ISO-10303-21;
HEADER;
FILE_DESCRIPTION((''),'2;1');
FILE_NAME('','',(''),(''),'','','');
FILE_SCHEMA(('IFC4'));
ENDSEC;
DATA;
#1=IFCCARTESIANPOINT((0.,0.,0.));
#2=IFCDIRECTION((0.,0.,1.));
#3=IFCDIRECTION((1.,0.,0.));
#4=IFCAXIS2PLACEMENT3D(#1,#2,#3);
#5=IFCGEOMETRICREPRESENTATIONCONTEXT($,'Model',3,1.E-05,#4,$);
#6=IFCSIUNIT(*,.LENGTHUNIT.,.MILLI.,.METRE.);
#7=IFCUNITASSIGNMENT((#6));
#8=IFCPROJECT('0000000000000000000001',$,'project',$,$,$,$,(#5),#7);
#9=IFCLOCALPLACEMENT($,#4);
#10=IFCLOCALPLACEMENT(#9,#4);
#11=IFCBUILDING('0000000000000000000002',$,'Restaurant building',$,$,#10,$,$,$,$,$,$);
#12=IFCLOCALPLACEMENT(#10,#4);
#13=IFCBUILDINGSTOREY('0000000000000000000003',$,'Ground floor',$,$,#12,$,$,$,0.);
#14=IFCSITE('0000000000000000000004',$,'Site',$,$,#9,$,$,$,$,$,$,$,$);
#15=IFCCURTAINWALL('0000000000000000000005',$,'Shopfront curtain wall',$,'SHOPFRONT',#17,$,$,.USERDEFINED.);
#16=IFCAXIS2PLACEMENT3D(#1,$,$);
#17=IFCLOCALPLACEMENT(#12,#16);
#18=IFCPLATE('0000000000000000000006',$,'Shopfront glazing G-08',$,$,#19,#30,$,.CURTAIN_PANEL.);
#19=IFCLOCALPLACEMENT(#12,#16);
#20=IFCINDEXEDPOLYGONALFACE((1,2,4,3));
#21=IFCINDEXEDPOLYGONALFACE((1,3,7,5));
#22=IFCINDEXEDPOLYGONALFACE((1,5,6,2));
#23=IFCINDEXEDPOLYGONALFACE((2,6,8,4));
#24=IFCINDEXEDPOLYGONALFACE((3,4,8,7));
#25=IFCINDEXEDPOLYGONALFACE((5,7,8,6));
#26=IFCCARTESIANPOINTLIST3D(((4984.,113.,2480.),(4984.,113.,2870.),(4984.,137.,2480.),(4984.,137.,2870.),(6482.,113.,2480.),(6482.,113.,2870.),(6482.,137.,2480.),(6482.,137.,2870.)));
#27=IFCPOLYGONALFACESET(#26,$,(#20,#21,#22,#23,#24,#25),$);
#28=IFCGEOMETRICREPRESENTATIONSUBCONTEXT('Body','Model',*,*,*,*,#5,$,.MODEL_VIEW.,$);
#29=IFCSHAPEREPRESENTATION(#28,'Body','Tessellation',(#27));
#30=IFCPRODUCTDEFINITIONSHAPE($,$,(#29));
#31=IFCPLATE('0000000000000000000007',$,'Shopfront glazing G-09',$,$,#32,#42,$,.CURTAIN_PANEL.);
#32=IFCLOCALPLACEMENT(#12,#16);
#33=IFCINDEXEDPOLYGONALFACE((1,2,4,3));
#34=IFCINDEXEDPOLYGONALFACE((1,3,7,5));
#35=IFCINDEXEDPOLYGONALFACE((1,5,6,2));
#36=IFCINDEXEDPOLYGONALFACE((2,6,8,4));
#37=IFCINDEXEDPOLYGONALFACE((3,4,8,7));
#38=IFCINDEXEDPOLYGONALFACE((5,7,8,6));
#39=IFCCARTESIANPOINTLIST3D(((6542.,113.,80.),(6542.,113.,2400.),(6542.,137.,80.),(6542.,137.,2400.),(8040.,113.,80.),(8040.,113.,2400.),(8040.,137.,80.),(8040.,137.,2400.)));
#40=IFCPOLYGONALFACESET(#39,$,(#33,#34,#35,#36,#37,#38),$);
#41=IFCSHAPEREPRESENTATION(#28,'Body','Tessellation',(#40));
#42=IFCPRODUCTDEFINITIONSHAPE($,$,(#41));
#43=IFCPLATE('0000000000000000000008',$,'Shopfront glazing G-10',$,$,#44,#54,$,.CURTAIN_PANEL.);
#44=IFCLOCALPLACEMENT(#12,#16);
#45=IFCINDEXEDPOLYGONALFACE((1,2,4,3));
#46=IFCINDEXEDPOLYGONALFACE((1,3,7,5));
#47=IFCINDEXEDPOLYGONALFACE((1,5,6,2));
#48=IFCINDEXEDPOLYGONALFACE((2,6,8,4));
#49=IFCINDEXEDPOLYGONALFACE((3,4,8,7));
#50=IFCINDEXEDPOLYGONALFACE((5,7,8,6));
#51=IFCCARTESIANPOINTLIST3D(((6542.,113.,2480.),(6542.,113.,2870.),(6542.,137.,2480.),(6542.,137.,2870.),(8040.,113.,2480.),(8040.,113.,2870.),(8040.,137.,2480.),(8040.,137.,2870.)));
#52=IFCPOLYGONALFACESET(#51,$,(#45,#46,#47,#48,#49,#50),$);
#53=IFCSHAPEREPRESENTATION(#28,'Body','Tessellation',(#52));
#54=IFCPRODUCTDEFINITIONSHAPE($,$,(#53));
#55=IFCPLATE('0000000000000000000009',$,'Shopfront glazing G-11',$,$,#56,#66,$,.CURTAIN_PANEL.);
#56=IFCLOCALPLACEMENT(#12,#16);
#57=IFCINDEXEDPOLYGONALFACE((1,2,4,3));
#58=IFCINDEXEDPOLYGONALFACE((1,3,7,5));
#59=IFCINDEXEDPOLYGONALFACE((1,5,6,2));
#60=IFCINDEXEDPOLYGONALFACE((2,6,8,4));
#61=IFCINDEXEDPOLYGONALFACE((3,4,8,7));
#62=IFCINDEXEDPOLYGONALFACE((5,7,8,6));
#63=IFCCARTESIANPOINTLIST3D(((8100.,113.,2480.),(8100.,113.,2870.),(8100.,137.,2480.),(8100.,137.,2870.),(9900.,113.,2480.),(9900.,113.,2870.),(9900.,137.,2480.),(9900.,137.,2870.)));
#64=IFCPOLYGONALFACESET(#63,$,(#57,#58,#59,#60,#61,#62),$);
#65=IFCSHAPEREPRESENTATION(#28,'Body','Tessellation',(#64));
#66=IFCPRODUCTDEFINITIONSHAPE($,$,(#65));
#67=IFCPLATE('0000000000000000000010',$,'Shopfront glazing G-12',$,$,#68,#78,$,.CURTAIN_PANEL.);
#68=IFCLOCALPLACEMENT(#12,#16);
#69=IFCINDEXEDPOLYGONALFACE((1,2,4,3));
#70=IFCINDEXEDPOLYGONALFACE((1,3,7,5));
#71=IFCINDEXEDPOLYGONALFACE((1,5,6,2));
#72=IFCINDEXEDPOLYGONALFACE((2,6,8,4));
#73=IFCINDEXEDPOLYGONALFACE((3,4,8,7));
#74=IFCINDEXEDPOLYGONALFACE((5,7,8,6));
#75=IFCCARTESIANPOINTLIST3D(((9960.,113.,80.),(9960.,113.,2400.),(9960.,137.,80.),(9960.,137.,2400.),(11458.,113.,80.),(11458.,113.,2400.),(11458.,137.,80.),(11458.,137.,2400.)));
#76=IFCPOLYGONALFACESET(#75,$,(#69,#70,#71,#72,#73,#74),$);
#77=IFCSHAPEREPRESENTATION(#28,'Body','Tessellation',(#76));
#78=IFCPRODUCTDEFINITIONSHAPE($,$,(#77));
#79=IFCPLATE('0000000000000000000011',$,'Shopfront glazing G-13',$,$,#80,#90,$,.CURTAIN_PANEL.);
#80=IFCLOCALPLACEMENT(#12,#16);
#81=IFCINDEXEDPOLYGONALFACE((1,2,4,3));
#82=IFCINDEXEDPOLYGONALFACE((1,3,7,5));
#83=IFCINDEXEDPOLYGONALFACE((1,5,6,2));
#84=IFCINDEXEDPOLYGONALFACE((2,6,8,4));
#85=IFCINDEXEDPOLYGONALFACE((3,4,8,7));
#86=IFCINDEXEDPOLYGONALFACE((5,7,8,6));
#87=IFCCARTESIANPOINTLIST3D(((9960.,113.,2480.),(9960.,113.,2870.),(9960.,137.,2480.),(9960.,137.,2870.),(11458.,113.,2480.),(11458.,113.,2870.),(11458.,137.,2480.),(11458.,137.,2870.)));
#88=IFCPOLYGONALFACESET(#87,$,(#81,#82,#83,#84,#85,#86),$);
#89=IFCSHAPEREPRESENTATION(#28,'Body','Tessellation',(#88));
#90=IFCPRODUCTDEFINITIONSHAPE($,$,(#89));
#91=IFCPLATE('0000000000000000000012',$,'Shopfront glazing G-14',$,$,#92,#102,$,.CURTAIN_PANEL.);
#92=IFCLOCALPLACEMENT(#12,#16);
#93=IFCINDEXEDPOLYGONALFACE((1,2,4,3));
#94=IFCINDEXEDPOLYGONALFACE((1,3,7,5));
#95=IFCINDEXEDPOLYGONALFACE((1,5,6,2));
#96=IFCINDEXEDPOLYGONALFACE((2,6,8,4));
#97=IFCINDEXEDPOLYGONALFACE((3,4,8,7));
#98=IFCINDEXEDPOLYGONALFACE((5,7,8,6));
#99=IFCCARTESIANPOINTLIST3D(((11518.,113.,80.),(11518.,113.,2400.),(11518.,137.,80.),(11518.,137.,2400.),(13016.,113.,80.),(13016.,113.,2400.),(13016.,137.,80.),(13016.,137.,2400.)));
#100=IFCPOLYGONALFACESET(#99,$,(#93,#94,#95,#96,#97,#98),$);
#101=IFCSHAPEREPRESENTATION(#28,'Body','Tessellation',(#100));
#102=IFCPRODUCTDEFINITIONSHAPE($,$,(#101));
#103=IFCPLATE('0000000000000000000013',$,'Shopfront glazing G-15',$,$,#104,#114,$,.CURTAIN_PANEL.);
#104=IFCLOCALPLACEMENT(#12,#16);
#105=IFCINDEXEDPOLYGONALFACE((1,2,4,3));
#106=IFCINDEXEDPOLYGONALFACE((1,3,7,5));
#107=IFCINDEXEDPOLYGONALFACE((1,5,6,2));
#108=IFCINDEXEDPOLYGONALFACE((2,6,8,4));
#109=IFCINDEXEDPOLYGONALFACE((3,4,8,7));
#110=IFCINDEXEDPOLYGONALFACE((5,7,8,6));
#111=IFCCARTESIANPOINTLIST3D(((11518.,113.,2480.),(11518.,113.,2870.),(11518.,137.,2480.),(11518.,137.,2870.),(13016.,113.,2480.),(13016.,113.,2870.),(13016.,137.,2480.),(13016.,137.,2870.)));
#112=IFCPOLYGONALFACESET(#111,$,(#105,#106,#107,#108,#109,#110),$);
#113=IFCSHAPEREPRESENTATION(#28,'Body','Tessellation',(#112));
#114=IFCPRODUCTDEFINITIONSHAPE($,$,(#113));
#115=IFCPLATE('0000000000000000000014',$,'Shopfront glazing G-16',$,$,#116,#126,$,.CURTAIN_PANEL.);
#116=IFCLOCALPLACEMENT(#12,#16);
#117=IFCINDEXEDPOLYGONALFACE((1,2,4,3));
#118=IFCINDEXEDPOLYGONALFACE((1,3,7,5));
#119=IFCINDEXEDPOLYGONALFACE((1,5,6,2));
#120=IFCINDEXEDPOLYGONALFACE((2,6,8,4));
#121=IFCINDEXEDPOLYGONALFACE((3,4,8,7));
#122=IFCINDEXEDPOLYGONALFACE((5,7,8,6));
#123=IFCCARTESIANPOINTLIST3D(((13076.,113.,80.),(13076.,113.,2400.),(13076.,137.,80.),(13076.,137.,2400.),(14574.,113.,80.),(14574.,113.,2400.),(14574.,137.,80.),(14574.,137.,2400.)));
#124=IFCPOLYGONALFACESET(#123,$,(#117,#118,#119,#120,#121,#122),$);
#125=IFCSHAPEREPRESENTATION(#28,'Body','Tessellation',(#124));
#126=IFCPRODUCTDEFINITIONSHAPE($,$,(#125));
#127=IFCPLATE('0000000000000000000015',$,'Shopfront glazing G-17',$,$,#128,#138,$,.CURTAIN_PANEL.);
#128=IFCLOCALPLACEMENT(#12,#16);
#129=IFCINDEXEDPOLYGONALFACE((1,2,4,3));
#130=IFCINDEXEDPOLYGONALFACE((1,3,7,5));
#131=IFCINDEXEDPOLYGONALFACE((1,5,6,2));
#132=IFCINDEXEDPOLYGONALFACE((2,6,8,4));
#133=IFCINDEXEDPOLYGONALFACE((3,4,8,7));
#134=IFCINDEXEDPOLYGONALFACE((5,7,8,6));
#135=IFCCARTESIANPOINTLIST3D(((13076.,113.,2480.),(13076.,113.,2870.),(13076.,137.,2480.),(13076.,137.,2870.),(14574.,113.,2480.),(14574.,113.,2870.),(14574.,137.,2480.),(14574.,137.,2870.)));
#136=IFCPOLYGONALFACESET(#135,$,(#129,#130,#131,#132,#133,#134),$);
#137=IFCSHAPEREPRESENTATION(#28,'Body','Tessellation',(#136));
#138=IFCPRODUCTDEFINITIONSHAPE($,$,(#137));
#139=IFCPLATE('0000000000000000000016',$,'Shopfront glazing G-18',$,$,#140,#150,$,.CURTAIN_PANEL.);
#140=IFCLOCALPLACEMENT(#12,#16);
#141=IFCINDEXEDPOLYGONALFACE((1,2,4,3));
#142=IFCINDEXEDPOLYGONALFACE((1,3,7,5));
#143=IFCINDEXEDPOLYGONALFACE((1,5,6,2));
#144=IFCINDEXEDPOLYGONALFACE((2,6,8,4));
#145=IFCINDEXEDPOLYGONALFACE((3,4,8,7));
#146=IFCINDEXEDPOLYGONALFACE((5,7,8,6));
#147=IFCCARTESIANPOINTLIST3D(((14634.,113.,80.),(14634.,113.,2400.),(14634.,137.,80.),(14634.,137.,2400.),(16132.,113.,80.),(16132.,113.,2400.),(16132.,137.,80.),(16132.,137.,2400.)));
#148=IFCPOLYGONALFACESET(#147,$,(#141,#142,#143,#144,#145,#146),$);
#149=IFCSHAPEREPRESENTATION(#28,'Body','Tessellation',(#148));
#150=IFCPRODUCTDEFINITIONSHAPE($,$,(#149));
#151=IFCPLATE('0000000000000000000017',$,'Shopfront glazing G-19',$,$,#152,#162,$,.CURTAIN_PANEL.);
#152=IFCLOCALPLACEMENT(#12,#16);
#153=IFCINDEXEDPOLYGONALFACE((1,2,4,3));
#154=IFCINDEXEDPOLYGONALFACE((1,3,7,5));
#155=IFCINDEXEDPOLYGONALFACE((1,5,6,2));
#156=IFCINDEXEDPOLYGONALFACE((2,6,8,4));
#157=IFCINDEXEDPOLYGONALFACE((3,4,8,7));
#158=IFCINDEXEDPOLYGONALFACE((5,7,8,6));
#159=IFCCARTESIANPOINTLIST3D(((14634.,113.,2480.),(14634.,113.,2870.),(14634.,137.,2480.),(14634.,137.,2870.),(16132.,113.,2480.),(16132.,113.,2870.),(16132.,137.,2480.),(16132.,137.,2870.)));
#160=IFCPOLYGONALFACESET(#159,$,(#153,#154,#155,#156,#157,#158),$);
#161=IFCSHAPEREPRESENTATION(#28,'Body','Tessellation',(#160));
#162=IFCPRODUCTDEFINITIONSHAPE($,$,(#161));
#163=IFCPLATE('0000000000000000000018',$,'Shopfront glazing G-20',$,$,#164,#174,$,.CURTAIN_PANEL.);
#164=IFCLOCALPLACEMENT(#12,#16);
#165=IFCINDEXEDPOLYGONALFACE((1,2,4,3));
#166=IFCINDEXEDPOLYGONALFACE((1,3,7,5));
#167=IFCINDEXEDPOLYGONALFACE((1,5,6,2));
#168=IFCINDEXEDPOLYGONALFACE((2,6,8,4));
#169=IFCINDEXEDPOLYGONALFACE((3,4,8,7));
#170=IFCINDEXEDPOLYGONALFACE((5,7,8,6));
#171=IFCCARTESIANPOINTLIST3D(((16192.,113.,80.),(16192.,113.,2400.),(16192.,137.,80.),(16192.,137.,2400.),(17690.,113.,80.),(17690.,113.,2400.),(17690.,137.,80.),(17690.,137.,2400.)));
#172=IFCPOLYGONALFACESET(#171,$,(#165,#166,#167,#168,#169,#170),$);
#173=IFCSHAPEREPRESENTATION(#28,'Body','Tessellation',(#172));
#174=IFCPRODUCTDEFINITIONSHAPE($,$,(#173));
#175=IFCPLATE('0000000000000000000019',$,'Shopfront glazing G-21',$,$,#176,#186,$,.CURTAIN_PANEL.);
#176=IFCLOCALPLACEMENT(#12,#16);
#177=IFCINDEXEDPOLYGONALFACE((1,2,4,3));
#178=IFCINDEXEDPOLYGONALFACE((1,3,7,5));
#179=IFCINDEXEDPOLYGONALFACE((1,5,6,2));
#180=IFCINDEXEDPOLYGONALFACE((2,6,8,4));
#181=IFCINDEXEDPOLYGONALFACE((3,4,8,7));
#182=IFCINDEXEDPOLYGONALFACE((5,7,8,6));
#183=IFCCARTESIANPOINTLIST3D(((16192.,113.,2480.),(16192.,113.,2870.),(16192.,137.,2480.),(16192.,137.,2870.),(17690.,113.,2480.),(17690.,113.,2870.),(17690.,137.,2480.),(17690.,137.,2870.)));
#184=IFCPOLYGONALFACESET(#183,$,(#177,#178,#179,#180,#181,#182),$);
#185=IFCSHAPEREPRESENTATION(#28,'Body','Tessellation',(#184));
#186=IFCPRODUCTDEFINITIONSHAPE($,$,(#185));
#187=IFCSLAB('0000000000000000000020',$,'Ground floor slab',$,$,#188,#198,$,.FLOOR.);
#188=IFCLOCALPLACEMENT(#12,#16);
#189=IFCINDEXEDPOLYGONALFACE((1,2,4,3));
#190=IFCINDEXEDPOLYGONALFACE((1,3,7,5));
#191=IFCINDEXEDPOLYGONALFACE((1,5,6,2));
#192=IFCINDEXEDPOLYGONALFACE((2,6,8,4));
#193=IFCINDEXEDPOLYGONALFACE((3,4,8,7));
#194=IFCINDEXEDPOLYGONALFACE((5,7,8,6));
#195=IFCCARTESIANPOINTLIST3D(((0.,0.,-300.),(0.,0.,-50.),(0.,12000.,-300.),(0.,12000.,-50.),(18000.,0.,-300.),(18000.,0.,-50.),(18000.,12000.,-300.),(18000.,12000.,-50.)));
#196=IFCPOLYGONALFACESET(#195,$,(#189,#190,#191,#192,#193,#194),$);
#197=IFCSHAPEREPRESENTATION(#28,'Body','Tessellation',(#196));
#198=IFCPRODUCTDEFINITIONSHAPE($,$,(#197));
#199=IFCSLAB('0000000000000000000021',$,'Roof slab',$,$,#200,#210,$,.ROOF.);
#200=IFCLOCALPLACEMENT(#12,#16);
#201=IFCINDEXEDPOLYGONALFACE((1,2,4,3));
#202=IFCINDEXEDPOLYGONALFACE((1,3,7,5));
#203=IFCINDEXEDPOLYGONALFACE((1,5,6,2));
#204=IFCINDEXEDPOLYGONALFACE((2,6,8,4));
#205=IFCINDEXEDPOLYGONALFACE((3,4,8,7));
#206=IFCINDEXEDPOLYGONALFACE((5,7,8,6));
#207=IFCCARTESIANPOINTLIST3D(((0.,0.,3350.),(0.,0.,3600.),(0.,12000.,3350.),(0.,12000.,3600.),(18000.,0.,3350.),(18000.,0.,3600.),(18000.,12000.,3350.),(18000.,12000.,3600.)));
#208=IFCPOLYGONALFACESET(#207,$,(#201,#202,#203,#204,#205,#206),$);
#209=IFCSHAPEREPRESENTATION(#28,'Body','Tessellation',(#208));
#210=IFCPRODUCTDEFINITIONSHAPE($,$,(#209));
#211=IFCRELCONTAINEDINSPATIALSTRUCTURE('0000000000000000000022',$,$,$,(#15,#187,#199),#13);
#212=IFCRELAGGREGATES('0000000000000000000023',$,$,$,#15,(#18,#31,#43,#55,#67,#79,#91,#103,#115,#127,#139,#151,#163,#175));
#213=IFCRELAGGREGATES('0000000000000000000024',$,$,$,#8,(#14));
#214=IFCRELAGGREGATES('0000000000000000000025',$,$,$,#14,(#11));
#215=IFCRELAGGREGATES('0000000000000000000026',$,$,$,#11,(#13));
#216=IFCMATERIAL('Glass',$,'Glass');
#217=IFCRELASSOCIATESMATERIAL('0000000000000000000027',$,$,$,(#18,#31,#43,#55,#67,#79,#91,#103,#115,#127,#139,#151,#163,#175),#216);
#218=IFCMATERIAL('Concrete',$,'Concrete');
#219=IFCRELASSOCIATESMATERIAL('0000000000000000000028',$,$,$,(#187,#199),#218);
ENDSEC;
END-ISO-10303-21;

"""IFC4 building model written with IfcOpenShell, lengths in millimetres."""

from ifc_helpers import new_model, si_unit, frame, origin, origin_with_axes, origin_2d, place, context, subcontext, project, spatial, rectangle, extrude, material, element, aggregate, save


model = new_model("IFC4")

# Units and contexts
model_context = context("Model", 3, precision=1e-05, world=origin_with_axes())
body_context = subcontext(model_context, "Body", "Model", "MODEL_VIEW")
ifc_project = project(units=[si_unit("LENGTHUNIT", "METRE", prefix="MILLI")], contexts=[model_context])

# Site, building, storey
site_placement = place(None, origin_with_axes())
site = spatial("IfcSite", under=ifc_project, at=site_placement, Name="Site")
building_placement = place(site_placement, origin_with_axes())
building = spatial("IfcBuilding", under=site, at=building_placement, Name="Restaurant building")
storey_placement = place(building_placement, origin_with_axes())
storey = spatial("IfcBuildingStorey", under=building, at=storey_placement, Name="Ground floor", Elevation=0.0)

# Curtain wall, plates
curtain_wall_placement = place(storey_placement, origin())
curtain_wall = element("IfcCurtainWall", 1, at=curtain_wall_placement, inside=storey, Name="Shopfront curtain wall", ObjectType="SHOPFRONT", PredefinedType="USERDEFINED")
ifc_material_1 = material(Name="Glass", Category="Glass")
plate_1_placement = place(curtain_wall_placement, origin_with_axes())
plate_1 = element("IfcPlate", 2, at=plate_1_placement, material=ifc_material_1, Name="Shopfront glazing G-08", PredefinedType="CURTAIN_PANEL", context=body_context, shape_type="SweptSolid", body=[
    extrude(rectangle(XDim=1498.0, YDim=24.0, at=origin_2d()), frame((5733.0, 125.0, 2480.0)), (0.0, 0.0, 1.0), 390.0),
])
plate_2_placement = place(curtain_wall_placement, origin_with_axes())
plate_2 = element("IfcPlate", 3, at=plate_2_placement, material=ifc_material_1, Name="Shopfront glazing G-09", PredefinedType="CURTAIN_PANEL", context=body_context, shape_type="SweptSolid", body=[
    extrude(rectangle(XDim=1498.0, YDim=24.0, at=origin_2d()), frame((7291.0, 125.0, 80.0)), (0.0, 0.0, 1.0), 2320.0),
])
plate_3_placement = place(curtain_wall_placement, origin_with_axes())
plate_3 = element("IfcPlate", 4, at=plate_3_placement, material=ifc_material_1, Name="Shopfront glazing G-10", PredefinedType="CURTAIN_PANEL", context=body_context, shape_type="SweptSolid", body=[
    extrude(rectangle(XDim=1498.0, YDim=24.0, at=origin_2d()), frame((7291.0, 125.0, 2480.0)), (0.0, 0.0, 1.0), 390.0),
])
plate_4_placement = place(curtain_wall_placement, origin_with_axes())
plate_4 = element("IfcPlate", 5, at=plate_4_placement, material=ifc_material_1, Name="Shopfront glazing G-11", PredefinedType="CURTAIN_PANEL", context=body_context, shape_type="SweptSolid", body=[
    extrude(rectangle(XDim=1800.0, YDim=24.0, at=origin_2d()), frame((9000.0, 125.0, 2480.0)), (0.0, 0.0, 1.0), 390.0),
])
plate_5_placement = place(curtain_wall_placement, origin_with_axes())
plate_5 = element("IfcPlate", 6, at=plate_5_placement, material=ifc_material_1, Name="Shopfront glazing G-12", PredefinedType="CURTAIN_PANEL", context=body_context, shape_type="SweptSolid", body=[
    extrude(rectangle(XDim=1498.0, YDim=24.0, at=origin_2d()), frame((10709.0, 125.0, 80.0)), (0.0, 0.0, 1.0), 2320.0),
])
plate_6_placement = place(curtain_wall_placement, origin_with_axes())
plate_6 = element("IfcPlate", 7, at=plate_6_placement, material=ifc_material_1, Name="Shopfront glazing G-13", PredefinedType="CURTAIN_PANEL", context=body_context, shape_type="SweptSolid", body=[
    extrude(rectangle(XDim=1498.0, YDim=24.0, at=origin_2d()), frame((10709.0, 125.0, 2480.0)), (0.0, 0.0, 1.0), 390.0),
])
plate_7_placement = place(curtain_wall_placement, origin_with_axes())
plate_7 = element("IfcPlate", 8, at=plate_7_placement, material=ifc_material_1, Name="Shopfront glazing G-14", PredefinedType="CURTAIN_PANEL", context=body_context, shape_type="SweptSolid", body=[
    extrude(rectangle(XDim=1498.0, YDim=24.0, at=origin_2d()), frame((12267.0, 125.0, 80.0)), (0.0, 0.0, 1.0), 2320.0),
])
plate_8_placement = place(curtain_wall_placement, origin_with_axes())
plate_8 = element("IfcPlate", 9, at=plate_8_placement, material=ifc_material_1, Name="Shopfront glazing G-15", PredefinedType="CURTAIN_PANEL", context=body_context, shape_type="SweptSolid", body=[
    extrude(rectangle(XDim=1498.0, YDim=24.0, at=origin_2d()), frame((12267.0, 125.0, 2480.0)), (0.0, 0.0, 1.0), 390.0),
])
plate_9_placement = place(curtain_wall_placement, origin_with_axes())
plate_9 = element("IfcPlate", 10, at=plate_9_placement, material=ifc_material_1, Name="Shopfront glazing G-16", PredefinedType="CURTAIN_PANEL", context=body_context, shape_type="SweptSolid", body=[
    extrude(rectangle(XDim=1498.0, YDim=24.0, at=origin_2d()), frame((13825.0, 125.0, 80.0)), (0.0, 0.0, 1.0), 2320.0),
])
plate_10_placement = place(curtain_wall_placement, origin_with_axes())
plate_10 = element("IfcPlate", 11, at=plate_10_placement, material=ifc_material_1, Name="Shopfront glazing G-17", PredefinedType="CURTAIN_PANEL", context=body_context, shape_type="SweptSolid", body=[
    extrude(rectangle(XDim=1498.0, YDim=24.0, at=origin_2d()), frame((13825.0, 125.0, 2480.0)), (0.0, 0.0, 1.0), 390.0),
])
plate_11_placement = place(curtain_wall_placement, origin_with_axes())
plate_11 = element("IfcPlate", 12, at=plate_11_placement, material=ifc_material_1, Name="Shopfront glazing G-18", PredefinedType="CURTAIN_PANEL", context=body_context, shape_type="SweptSolid", body=[
    extrude(rectangle(XDim=1498.0, YDim=24.0, at=origin_2d()), frame((15383.0, 125.0, 80.0)), (0.0, 0.0, 1.0), 2320.0),
])
plate_12_placement = place(curtain_wall_placement, origin_with_axes())
plate_12 = element("IfcPlate", 13, at=plate_12_placement, material=ifc_material_1, Name="Shopfront glazing G-19", PredefinedType="CURTAIN_PANEL", context=body_context, shape_type="SweptSolid", body=[
    extrude(rectangle(XDim=1498.0, YDim=24.0, at=origin_2d()), frame((15383.0, 125.0, 2480.0)), (0.0, 0.0, 1.0), 390.0),
])
plate_13_placement = place(curtain_wall_placement, origin_with_axes())
plate_13 = element("IfcPlate", 14, at=plate_13_placement, material=ifc_material_1, Name="Shopfront glazing G-20", PredefinedType="CURTAIN_PANEL", context=body_context, shape_type="SweptSolid", body=[
    extrude(rectangle(XDim=1498.0, YDim=24.0, at=origin_2d()), frame((16941.0, 125.0, 80.0)), (0.0, 0.0, 1.0), 2320.0),
])
plate_14_placement = place(curtain_wall_placement, origin_with_axes())
plate_14 = element("IfcPlate", 15, at=plate_14_placement, material=ifc_material_1, Name="Shopfront glazing G-21", PredefinedType="CURTAIN_PANEL", context=body_context, shape_type="SweptSolid", body=[
    extrude(rectangle(XDim=1498.0, YDim=24.0, at=origin_2d()), frame((16941.0, 125.0, 2480.0)), (0.0, 0.0, 1.0), 390.0),
])
aggregate(curtain_wall, [plate_1, plate_2, plate_3, plate_4, plate_5, plate_6, plate_7, plate_8, plate_9, plate_10, plate_11, plate_12, plate_13, plate_14])

# Slabs
ifc_material_2 = material(Name="Concrete", Category="Concrete")
slab_1_placement = place(storey_placement, origin())
element("IfcSlab", 16, at=slab_1_placement, inside=storey, material=ifc_material_2, Name="Ground floor slab", PredefinedType="FLOOR", context=body_context, shape_type="SweptSolid", body=[
    extrude(rectangle(XDim=18000.0, YDim=12000.0, at=origin_2d()), frame((9000.0, 6000.0, -300.0)), (0.0, 0.0, 1.0), 250.0),
])
slab_2_placement = place(storey_placement, origin())
element("IfcSlab", 17, at=slab_2_placement, inside=storey, material=ifc_material_2, Name="Roof slab", PredefinedType="ROOF", context=body_context, shape_type="SweptSolid", body=[
    extrude(rectangle(XDim=18000.0, YDim=12000.0, at=origin_2d()), frame((9000.0, 6000.0, 3350.0)), (0.0, 0.0, 1.0), 250.0),
])

save(model, "model.ifc")
